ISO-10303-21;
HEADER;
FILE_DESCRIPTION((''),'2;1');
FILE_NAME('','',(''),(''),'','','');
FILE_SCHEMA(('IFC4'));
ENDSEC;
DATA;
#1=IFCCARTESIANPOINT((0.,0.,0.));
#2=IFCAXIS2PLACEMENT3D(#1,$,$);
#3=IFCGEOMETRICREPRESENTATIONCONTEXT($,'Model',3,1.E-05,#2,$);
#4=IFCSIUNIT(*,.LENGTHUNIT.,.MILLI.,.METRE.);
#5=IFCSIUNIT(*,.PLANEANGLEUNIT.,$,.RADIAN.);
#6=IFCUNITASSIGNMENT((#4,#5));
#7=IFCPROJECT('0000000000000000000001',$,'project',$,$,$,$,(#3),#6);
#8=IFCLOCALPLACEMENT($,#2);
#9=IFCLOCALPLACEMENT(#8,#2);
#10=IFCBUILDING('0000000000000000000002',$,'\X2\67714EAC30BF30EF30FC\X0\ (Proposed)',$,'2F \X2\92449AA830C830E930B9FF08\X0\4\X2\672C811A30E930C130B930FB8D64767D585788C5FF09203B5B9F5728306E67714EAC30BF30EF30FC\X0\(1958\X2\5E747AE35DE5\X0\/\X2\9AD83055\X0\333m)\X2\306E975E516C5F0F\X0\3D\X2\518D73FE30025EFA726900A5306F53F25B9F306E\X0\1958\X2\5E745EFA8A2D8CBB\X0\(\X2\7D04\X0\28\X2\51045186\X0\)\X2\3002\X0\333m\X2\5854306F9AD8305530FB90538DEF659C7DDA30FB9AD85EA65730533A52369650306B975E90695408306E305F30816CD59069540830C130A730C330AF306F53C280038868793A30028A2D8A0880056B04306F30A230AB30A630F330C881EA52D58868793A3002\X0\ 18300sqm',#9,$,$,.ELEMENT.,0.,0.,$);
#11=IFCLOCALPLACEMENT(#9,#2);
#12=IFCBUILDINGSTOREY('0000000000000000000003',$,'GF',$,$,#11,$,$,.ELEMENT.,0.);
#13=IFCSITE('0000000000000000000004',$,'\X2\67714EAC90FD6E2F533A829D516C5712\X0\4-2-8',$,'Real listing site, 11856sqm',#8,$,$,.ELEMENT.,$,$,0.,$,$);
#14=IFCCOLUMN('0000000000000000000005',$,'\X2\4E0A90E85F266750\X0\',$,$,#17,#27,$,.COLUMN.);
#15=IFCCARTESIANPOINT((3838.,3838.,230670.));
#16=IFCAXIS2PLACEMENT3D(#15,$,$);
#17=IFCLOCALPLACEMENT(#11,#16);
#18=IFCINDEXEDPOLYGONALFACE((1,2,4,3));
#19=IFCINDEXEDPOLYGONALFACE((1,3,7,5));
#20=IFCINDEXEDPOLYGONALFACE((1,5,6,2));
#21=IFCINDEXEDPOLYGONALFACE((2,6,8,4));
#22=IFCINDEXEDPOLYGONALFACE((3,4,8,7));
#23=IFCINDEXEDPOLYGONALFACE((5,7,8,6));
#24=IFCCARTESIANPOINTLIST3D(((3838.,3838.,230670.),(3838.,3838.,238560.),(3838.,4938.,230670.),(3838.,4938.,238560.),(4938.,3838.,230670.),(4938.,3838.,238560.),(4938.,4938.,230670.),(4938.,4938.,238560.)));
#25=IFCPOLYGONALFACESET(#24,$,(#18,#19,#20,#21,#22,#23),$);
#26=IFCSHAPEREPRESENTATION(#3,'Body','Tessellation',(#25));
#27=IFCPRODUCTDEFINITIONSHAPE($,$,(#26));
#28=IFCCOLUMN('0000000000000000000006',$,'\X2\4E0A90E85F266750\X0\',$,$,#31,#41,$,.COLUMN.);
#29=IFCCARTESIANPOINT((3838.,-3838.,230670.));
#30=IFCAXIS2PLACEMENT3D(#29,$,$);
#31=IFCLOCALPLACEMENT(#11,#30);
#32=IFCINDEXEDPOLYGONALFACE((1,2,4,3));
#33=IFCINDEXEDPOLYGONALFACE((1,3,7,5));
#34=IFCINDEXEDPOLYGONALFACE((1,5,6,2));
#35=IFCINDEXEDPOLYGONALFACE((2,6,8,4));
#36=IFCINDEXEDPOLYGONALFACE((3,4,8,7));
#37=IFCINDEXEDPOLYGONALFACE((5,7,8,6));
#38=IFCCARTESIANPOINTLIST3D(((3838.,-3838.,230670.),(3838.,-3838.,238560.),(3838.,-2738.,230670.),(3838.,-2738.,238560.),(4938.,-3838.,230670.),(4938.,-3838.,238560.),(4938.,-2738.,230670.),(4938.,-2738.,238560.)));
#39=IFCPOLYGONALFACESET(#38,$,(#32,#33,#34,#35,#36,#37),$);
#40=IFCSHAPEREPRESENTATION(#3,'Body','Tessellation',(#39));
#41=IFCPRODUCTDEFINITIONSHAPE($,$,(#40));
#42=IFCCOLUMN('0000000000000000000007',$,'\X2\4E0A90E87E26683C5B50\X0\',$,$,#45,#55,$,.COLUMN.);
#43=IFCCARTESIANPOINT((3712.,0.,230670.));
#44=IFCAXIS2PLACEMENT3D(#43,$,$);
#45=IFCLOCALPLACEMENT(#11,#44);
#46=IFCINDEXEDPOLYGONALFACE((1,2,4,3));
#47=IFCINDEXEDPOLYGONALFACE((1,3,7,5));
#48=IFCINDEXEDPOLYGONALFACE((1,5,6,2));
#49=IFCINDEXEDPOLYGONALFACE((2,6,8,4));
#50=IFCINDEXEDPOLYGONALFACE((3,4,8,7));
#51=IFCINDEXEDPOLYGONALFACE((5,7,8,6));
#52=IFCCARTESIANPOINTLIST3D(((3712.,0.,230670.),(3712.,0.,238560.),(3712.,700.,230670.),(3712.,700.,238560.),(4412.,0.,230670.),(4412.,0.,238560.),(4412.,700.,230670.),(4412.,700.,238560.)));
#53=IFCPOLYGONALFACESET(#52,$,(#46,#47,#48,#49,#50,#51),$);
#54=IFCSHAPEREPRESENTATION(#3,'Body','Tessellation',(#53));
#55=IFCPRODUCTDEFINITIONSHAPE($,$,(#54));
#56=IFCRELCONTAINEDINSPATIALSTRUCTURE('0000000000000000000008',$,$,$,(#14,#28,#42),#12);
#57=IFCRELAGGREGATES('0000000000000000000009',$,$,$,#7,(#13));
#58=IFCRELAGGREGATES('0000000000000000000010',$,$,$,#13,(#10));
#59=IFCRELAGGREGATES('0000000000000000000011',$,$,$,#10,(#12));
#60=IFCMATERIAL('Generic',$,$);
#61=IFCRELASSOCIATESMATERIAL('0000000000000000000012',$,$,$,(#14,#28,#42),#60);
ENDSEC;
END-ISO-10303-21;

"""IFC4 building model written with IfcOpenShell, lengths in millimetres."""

from ifc_helpers import new_model, si_unit, frame, frame_2d, origin, place, context, project, spatial, rectangle, extrude, material, element, save


model = new_model("IFC4")

# Units and contexts
model_context = context("Model", 3, precision=1e-05, world=origin())
ifc_project = project(units=[si_unit("LENGTHUNIT", "METRE", prefix="MILLI"), si_unit("PLANEANGLEUNIT", "RADIAN")], contexts=[model_context])

# Site, building, storey
site_placement = place(None, origin())
site = spatial("IfcSite", under=ifc_project, at=site_placement, Name="東京都港区芝公園4-2-8", ObjectType="Real listing site, 11856sqm", CompositionType="ELEMENT", RefElevation=0.0)
building_placement = place(site_placement, origin())
building = spatial("IfcBuilding", under=site, at=building_placement, Name="東京タワー (Proposed)", ObjectType="2F 鉄骨トラス（4本脚ラチス・赤白塗装）※実在の東京タワー(1958年竣工/高さ333m)の非公式3D再現。建物¥は史実の1958年建設費(約28億円)。333m塔は高さ・道路斜線・高度地区制限に非適合のため法適合チェックは参考表示。設計者欄はアカウント自動表示。 18300sqm", CompositionType="ELEMENT", ElevationOfRefHeight=0.0, ElevationOfTerrain=0.0)
storey_placement = place(building_placement, origin())
storey = spatial("IfcBuildingStorey", under=building, at=storey_placement, Name="GF", CompositionType="ELEMENT", Elevation=0.0)

# Columns
ifc_material = material(Name="Generic")
column_1_placement = place(storey_placement, frame((3838.0, 3838.0, 230670.0)))
element("IfcColumn", 1, at=column_1_placement, inside=storey, material=ifc_material, Name="上部弦材", PredefinedType="COLUMN", context=model_context, shape_type="SweptSolid", body=[
    extrude(rectangle(XDim=1100.0, YDim=1100.0, at=frame_2d((550.0, 550.0))), frame((3838.0, 3838.0, 230670.0)), (0.0, 0.0, 1.0), 7890.0),
])
column_2_placement = place(storey_placement, frame((3838.0, -3838.0, 230670.0)))
element("IfcColumn", 2, at=column_2_placement, inside=storey, material=ifc_material, Name="上部弦材", PredefinedType="COLUMN", context=model_context, shape_type="SweptSolid", body=[
    extrude(rectangle(XDim=1100.0, YDim=1100.0, at=frame_2d((550.0, 550.0))), frame((3838.0, -3838.0, 230670.0)), (0.0, 0.0, 1.0), 7890.0),
])
column_3_placement = place(storey_placement, frame((3712.0, 0.0, 230670.0)))
element("IfcColumn", 3, at=column_3_placement, inside=storey, material=ifc_material, Name="上部縦格子", PredefinedType="COLUMN", context=model_context, shape_type="SweptSolid", body=[
    extrude(rectangle(XDim=700.0, YDim=700.0, at=frame_2d((350.0, 350.0))), frame((3712.0, 0.0, 230670.0)), (0.0, 0.0, 1.0), 7890.0),
])

save(model, "model.ifc")
